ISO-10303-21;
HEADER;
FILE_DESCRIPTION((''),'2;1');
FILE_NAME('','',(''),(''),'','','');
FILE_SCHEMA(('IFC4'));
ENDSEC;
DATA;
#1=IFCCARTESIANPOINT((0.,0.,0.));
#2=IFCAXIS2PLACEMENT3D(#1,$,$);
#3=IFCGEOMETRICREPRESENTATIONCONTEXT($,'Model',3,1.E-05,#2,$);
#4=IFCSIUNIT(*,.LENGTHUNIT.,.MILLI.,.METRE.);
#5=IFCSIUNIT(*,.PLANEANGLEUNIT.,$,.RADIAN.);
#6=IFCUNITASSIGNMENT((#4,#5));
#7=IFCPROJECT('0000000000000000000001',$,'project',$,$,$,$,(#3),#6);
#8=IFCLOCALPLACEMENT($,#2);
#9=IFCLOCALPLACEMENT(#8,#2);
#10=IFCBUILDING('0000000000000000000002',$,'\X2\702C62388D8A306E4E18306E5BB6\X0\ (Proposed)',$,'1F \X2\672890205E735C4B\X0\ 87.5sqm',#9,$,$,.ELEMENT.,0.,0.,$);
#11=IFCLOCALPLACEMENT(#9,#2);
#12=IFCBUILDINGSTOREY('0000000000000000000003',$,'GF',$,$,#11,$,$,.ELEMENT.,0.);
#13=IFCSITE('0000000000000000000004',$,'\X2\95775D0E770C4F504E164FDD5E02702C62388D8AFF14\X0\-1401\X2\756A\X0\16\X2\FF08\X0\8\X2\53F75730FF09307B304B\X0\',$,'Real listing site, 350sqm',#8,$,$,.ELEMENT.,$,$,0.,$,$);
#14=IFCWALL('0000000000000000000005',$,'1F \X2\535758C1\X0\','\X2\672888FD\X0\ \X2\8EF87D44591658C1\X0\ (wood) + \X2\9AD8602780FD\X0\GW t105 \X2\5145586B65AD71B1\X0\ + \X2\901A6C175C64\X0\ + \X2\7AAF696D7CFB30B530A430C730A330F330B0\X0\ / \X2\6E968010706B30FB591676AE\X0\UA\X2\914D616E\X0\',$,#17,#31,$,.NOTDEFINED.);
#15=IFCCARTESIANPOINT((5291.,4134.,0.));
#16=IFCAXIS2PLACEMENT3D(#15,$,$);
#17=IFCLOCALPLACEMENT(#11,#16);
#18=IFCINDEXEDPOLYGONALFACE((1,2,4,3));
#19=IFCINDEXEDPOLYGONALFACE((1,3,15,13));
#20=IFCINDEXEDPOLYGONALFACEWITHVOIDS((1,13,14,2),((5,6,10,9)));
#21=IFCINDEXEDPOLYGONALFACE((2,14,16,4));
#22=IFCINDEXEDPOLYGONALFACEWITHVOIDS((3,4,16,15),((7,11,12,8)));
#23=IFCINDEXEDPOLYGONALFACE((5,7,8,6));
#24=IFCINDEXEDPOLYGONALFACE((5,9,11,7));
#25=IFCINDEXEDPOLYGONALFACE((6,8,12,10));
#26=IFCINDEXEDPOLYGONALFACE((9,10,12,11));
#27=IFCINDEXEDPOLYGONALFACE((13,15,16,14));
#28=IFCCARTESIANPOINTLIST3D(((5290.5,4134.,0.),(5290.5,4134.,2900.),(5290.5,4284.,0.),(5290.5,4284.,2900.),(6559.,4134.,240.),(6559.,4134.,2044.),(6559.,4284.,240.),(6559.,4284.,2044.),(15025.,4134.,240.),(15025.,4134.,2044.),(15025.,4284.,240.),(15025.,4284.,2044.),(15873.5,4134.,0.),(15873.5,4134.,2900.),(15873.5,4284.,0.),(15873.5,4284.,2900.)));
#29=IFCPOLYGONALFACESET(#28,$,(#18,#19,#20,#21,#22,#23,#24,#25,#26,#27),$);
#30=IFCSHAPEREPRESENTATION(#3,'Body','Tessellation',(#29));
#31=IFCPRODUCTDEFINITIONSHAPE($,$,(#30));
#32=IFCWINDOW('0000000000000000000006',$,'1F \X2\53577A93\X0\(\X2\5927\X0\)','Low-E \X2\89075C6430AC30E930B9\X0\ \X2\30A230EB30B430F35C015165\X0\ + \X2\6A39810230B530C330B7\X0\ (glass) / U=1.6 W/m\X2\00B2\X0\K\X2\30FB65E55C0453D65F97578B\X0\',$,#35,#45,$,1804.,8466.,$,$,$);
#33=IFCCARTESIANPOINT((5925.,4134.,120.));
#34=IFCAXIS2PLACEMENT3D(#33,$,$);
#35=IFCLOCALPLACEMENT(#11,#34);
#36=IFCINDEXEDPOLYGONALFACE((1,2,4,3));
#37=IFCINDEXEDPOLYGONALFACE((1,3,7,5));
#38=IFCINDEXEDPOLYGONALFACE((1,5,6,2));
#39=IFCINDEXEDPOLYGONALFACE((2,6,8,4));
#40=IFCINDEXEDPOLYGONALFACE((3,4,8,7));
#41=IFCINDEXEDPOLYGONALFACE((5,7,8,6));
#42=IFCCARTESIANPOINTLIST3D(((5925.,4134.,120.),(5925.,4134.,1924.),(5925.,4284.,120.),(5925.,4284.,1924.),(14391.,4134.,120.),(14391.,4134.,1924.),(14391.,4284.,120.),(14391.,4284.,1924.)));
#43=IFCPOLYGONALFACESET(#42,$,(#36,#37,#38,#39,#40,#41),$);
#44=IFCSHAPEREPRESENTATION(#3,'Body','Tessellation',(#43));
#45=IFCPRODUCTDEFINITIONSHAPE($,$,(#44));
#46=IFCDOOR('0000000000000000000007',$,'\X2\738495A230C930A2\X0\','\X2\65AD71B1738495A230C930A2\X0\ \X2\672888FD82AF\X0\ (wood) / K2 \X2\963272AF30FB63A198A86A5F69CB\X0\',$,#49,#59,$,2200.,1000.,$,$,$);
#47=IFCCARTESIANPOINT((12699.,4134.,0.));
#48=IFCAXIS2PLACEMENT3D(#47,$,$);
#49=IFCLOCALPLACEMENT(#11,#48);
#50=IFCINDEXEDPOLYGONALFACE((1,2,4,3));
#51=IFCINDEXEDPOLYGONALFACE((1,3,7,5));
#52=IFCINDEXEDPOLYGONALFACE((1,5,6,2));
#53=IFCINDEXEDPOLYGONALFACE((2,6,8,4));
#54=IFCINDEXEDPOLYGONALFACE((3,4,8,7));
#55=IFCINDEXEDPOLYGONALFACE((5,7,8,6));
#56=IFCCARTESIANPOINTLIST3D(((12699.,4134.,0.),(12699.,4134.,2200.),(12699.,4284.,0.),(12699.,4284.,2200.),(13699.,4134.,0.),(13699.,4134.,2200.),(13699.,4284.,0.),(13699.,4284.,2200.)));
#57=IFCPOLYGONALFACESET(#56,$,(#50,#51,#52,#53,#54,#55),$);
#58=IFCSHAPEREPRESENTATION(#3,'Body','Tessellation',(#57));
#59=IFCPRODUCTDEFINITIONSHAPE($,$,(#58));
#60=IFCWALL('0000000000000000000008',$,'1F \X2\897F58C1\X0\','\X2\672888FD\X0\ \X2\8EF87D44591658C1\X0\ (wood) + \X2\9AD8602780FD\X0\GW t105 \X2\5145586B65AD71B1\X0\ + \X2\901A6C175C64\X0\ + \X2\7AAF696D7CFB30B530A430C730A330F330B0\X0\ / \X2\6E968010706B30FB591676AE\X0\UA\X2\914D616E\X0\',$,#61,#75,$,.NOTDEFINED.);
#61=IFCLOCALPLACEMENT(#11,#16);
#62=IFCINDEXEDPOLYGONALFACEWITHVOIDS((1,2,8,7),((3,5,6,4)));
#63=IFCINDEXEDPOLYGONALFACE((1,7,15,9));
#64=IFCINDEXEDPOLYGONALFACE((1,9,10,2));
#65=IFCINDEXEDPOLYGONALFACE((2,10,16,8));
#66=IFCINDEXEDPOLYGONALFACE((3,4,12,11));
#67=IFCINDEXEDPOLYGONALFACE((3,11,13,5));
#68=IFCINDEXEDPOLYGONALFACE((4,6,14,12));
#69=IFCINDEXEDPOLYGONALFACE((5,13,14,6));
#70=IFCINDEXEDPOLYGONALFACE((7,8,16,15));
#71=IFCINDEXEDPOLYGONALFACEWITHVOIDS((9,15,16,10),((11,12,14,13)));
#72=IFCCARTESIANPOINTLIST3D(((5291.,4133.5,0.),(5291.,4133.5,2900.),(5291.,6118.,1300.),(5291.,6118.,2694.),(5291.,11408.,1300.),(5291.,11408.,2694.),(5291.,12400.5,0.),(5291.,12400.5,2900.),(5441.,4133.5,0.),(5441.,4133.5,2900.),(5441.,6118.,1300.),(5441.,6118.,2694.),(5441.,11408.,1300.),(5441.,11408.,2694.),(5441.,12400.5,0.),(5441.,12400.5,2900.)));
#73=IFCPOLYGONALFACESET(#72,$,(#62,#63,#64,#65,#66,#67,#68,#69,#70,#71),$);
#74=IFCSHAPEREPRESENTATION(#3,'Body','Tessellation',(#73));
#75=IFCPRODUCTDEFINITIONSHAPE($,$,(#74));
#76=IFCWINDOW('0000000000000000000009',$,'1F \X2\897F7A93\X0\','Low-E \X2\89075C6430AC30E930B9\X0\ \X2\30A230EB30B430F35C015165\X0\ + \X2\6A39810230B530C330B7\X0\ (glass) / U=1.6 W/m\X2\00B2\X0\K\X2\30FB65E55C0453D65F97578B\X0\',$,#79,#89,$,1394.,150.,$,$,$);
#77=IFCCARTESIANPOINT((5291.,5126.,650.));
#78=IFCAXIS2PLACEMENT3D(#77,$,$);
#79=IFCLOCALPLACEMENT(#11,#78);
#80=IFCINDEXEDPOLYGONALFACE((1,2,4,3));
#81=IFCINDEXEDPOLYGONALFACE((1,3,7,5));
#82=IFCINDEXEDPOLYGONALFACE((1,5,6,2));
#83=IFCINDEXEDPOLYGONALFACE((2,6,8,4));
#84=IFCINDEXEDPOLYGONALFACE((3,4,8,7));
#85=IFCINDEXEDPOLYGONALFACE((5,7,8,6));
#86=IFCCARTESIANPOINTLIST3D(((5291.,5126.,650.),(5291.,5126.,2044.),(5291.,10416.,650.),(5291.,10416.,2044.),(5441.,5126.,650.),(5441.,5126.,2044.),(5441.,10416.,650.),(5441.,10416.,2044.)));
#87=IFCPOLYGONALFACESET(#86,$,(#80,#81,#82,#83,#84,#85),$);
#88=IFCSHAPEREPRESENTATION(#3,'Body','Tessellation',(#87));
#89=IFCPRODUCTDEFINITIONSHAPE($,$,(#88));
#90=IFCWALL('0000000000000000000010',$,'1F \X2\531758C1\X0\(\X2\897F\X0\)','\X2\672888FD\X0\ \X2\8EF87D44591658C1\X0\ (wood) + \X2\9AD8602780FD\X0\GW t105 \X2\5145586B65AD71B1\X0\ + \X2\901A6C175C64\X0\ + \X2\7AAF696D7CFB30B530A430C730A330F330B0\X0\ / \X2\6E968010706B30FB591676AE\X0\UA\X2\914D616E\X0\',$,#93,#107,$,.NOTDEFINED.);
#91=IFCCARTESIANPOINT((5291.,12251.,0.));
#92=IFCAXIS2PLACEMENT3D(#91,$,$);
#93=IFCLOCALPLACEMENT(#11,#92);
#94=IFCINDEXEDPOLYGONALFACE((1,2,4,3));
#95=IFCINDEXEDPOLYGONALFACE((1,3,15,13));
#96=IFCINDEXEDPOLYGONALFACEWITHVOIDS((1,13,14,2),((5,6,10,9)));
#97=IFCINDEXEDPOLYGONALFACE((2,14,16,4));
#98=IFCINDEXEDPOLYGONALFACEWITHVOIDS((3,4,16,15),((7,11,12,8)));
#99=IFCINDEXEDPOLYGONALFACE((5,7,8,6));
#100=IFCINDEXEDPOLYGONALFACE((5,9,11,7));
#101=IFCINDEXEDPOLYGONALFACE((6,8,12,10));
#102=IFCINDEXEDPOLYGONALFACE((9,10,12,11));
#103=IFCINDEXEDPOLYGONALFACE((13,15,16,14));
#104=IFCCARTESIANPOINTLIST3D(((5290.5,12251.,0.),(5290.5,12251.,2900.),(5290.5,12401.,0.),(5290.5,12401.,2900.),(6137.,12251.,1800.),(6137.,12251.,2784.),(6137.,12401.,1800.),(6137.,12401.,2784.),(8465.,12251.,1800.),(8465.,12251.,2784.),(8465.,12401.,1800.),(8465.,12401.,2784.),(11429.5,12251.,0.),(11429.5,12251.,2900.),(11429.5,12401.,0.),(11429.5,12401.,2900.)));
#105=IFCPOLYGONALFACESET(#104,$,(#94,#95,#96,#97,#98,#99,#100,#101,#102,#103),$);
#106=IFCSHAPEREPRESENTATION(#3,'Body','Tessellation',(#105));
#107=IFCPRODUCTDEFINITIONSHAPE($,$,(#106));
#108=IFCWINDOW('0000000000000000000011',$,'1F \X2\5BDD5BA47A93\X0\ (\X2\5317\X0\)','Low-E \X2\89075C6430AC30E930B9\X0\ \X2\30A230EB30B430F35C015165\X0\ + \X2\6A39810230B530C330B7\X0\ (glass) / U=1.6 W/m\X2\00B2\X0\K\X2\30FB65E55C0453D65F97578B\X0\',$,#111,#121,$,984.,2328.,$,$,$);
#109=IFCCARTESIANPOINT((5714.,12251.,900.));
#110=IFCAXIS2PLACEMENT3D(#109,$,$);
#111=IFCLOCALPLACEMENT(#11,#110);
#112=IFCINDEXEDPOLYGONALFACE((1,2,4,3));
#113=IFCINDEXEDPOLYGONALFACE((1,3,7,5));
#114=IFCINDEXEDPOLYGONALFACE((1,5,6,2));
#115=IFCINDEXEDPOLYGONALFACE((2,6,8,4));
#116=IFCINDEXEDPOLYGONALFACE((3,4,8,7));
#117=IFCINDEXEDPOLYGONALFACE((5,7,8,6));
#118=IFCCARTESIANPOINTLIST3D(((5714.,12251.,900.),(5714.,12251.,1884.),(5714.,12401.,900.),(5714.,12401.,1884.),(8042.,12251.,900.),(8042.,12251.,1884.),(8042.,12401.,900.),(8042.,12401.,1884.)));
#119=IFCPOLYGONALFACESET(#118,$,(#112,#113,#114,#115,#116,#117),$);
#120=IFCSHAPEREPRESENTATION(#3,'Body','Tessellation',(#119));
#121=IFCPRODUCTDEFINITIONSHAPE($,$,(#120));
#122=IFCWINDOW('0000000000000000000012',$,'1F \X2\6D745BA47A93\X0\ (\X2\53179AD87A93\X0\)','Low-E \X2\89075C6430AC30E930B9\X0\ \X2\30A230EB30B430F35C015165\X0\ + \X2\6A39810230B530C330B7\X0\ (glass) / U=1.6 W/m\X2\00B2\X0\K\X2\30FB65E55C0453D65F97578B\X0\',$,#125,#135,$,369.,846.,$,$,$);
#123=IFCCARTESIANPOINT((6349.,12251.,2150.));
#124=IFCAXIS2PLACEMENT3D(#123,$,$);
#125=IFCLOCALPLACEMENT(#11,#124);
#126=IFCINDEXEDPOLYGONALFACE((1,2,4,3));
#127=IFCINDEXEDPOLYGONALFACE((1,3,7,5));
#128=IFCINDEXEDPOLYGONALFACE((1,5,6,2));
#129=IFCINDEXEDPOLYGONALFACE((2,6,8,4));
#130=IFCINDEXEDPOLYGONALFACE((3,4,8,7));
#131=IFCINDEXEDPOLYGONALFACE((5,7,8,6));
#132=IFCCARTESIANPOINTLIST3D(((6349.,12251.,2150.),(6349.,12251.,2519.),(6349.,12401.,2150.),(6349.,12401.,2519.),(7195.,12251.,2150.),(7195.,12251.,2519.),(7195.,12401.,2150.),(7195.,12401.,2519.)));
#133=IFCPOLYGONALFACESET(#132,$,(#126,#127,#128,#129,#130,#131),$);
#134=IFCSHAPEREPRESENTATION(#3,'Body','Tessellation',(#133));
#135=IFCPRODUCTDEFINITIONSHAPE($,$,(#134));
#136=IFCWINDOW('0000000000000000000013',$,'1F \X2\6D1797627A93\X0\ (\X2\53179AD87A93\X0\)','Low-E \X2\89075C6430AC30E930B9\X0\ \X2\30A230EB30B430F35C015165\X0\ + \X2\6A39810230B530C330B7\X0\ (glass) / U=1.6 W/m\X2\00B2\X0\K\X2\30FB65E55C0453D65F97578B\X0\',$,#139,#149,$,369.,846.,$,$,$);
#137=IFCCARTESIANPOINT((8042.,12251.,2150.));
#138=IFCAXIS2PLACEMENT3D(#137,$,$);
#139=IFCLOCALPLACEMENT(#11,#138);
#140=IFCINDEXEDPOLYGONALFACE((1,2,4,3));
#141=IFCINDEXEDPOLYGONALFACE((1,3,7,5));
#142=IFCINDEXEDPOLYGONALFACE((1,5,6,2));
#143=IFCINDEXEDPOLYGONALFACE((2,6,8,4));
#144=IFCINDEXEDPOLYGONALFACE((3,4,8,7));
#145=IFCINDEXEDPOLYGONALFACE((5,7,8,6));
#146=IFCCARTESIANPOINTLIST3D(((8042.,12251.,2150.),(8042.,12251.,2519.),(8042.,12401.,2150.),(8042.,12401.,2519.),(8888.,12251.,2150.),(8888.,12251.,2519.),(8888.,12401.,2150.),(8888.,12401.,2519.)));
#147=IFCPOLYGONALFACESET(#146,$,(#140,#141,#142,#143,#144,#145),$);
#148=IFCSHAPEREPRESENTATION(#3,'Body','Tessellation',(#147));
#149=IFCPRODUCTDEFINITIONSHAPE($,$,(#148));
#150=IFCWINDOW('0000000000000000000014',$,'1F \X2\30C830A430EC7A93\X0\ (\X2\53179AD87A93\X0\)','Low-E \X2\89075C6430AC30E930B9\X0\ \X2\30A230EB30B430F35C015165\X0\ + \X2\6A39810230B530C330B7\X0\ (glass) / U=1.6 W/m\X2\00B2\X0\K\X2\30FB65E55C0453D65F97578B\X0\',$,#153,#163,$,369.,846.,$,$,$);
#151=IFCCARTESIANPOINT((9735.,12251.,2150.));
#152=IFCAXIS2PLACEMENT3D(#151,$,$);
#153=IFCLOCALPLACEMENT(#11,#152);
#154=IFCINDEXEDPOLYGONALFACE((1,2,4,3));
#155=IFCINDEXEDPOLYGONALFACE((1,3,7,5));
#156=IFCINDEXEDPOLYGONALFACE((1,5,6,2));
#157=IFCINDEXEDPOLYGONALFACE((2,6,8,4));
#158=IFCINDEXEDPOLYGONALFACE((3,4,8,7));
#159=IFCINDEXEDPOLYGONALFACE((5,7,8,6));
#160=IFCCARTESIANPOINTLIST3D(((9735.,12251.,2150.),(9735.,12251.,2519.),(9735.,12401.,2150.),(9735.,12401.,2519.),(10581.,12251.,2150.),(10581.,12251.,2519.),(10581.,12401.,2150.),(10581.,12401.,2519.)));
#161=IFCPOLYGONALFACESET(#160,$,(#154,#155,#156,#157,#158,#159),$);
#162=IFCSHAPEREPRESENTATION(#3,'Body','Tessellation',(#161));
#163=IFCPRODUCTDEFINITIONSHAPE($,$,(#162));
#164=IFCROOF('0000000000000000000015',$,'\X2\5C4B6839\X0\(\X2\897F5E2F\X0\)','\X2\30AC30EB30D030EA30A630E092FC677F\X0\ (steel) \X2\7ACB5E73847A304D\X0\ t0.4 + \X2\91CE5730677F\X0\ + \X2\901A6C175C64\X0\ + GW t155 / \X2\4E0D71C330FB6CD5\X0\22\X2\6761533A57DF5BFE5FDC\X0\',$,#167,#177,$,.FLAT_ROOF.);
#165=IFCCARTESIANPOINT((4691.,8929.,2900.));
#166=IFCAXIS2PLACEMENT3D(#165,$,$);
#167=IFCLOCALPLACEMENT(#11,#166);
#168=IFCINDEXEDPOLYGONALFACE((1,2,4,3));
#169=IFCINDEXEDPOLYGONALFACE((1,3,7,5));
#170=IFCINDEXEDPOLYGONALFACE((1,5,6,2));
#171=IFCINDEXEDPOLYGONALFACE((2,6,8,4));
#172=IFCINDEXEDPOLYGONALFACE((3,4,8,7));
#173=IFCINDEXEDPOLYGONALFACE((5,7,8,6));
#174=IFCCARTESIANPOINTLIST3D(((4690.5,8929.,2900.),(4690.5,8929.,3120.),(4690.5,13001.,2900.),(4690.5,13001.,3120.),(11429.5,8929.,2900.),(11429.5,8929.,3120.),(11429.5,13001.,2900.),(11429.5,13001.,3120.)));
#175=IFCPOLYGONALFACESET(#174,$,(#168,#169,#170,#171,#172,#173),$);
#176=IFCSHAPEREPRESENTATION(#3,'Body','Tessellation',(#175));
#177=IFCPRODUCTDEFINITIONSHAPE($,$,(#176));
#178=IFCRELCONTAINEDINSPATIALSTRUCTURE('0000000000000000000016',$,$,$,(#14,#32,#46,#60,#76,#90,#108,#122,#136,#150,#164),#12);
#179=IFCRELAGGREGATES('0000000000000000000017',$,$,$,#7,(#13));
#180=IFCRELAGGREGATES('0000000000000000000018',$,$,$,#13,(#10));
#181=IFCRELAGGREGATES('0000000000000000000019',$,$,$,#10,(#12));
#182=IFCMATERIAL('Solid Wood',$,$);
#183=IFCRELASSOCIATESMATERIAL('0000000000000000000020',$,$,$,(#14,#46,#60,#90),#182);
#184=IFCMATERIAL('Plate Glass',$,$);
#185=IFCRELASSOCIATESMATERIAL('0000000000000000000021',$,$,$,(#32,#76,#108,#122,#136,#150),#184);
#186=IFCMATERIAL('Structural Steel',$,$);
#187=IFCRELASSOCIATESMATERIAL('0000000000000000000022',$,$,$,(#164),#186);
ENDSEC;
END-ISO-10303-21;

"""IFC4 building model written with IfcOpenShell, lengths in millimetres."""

from ifc_helpers import new_model, si_unit, frame, frame_2d, origin, place, context, project, spatial, rectangle, extrude, material, element, fill, save


model = new_model("IFC4")

# Units and contexts
model_context = context("Model", 3, precision=1e-05, world=origin())
ifc_project = project(units=[si_unit("LENGTHUNIT", "METRE", prefix="MILLI"), si_unit("PLANEANGLEUNIT", "RADIAN")], contexts=[model_context])

# Site, building, storey
site_placement = place(None, origin())
site = spatial("IfcSite", under=ifc_project, at=site_placement, Name="長崎県佐世保市瀬戸越４-1401番16（8号地）ほか", ObjectType="Real listing site, 350sqm", CompositionType="ELEMENT", RefElevation=0.0)
building_placement = place(site_placement, origin())
building = spatial("IfcBuilding", under=site, at=building_placement, Name="瀬戸越の丘の家 (Proposed)", ObjectType="1F 木造平屋 87.5sqm", CompositionType="ELEMENT", ElevationOfRefHeight=0.0, ElevationOfTerrain=0.0)
storey_placement = place(building_placement, origin())
storey = spatial("IfcBuildingStorey", under=building, at=storey_placement, Name="GF", CompositionType="ELEMENT", Elevation=0.0)

# Shared definitions
ifc_material_1 = material(Name="Solid Wood")

# Wall, openings, window, door
wall_1_placement = place(storey_placement, frame((5291.0, 4134.0, 0.0)))
wall_1 = element("IfcWall", 1, at=wall_1_placement, inside=storey, material=ifc_material_1, Name="1F 南壁", Description="木製 軸組外壁 (wood) + 高性能GW t105 充填断熱 + 通気層 + 窯業系サイディング / 準耐火・外皮UA配慮", PredefinedType="NOTDEFINED", context=model_context, shape_type="SweptSolid", body=[
    extrude(rectangle(XDim=10583.0, YDim=150.0, at=frame_2d((5291.0, 75.0))), frame((5291.0, 4134.0, 0.0)), (0.0, 0.0, 1.0), 2900.0),
])
opening_1_placement = place(storey_placement, frame((5925.0, 4134.0, 120.0)))
opening_1 = element("IfcOpeningElement", 2, at=opening_1_placement, cuts=wall_1, PredefinedType="NOTDEFINED", context=model_context, shape_type="SweptSolid", body=[
    extrude(rectangle(XDim=8466.0, YDim=150.0, at=frame_2d((4233.0, 75.0))), frame((5925.0, 4134.0, 120.0)), (0.0, 0.0, 1.0), 1804.0),
])
opening_2_placement = place(storey_placement, frame((12699.0, 4134.0, 0.0)))
opening_2 = element("IfcOpeningElement", 3, at=opening_2_placement, cuts=wall_1, PredefinedType="NOTDEFINED", context=model_context, shape_type="SweptSolid", body=[
    extrude(rectangle(XDim=1000.0, YDim=150.0, at=frame_2d((500.0, 75.0))), frame((12699.0, 4134.0, 0.0)), (0.0, 0.0, 1.0), 2200.0),
])
ifc_material_2 = material(Name="Plate Glass")
window_1_placement = place(storey_placement, frame((5925.0, 4134.0, 120.0)))
window_1 = element("IfcWindow", 4, at=window_1_placement, inside=storey, material=ifc_material_2, Name="1F 南窓(大)", Description="Low-E 複層ガラス アルゴン封入 + 樹脂サッシ (glass) / U=1.6 W/m²K・日射取得型", OverallHeight=1804.0, OverallWidth=8466.0, context=model_context, shape_type="SweptSolid", body=[
    extrude(rectangle(XDim=8466.0, YDim=150.0, at=frame_2d((4233.0, 75.0))), frame((5925.0, 4134.0, 120.0)), (0.0, 0.0, 1.0), 1804.0),
])
fill(opening_1, window_1)
door_1_placement = place(storey_placement, frame((12699.0, 4134.0, 0.0)))
door_1 = element("IfcDoor", 5, at=door_1_placement, inside=storey, material=ifc_material_1, Name="玄関ドア", Description="断熱玄関ドア 木製芯 (wood) / K2 防犯・採風機構", OverallHeight=2200.0, OverallWidth=1000.0, context=model_context, shape_type="SweptSolid", body=[
    extrude(rectangle(XDim=1000.0, YDim=150.0, at=frame_2d((500.0, 75.0))), frame((12699.0, 4134.0, 0.0)), (0.0, 0.0, 1.0), 2200.0),
])
fill(opening_2, door_1)

# Wall, opening, window
wall_2_placement = place(storey_placement, frame((5291.0, 4134.0, 0.0)))
wall_2 = element("IfcWall", 6, at=wall_2_placement, inside=storey, material=ifc_material_1, Name="1F 西壁", Description="木製 軸組外壁 (wood) + 高性能GW t105 充填断熱 + 通気層 + 窯業系サイディング / 準耐火・外皮UA配慮", PredefinedType="NOTDEFINED", context=model_context, shape_type="SweptSolid", body=[
    extrude(rectangle(XDim=150.0, YDim=8267.0, at=frame_2d((75.0, 4133.0))), frame((5291.0, 4134.0, 0.0)), (0.0, 0.0, 1.0), 2900.0),
])
opening_3_placement = place(storey_placement, frame((5291.0, 5126.0, 650.0)))
opening_3 = element("IfcOpeningElement", 7, at=opening_3_placement, cuts=wall_2, PredefinedType="NOTDEFINED", context=model_context, shape_type="SweptSolid", body=[
    extrude(rectangle(XDim=150.0, YDim=5290.0, at=frame_2d((75.0, 2645.0))), frame((5291.0, 5126.0, 650.0)), (0.0, 0.0, 1.0), 1394.0),
])
window_2_placement = place(storey_placement, frame((5291.0, 5126.0, 650.0)))
window_2 = element("IfcWindow", 8, at=window_2_placement, inside=storey, material=ifc_material_2, Name="1F 西窓", Description="Low-E 複層ガラス アルゴン封入 + 樹脂サッシ (glass) / U=1.6 W/m²K・日射取得型", OverallHeight=1394.0, OverallWidth=150.0, context=model_context, shape_type="SweptSolid", body=[
    extrude(rectangle(XDim=150.0, YDim=5290.0, at=frame_2d((75.0, 2645.0))), frame((5291.0, 5126.0, 650.0)), (0.0, 0.0, 1.0), 1394.0),
])
fill(opening_3, window_2)

# Wall, openings, windows
wall_3_placement = place(storey_placement, frame((5291.0, 12251.0, 0.0)))
wall_3 = element("IfcWall", 9, at=wall_3_placement, inside=storey, material=ifc_material_1, Name="1F 北壁(西)", Description="木製 軸組外壁 (wood) + 高性能GW t105 充填断熱 + 通気層 + 窯業系サイディング / 準耐火・外皮UA配慮", PredefinedType="NOTDEFINED", context=model_context, shape_type="SweptSolid", body=[
    extrude(rectangle(XDim=6139.0, YDim=150.0, at=frame_2d((3069.0, 75.0))), frame((5291.0, 12251.0, 0.0)), (0.0, 0.0, 1.0), 2900.0),
])
opening_4_placement = place(storey_placement, frame((5714.0, 12251.0, 900.0)))
opening_4 = element("IfcOpeningElement", 10, at=opening_4_placement, cuts=wall_3, PredefinedType="NOTDEFINED", context=model_context, shape_type="SweptSolid", body=[
    extrude(rectangle(XDim=2328.0, YDim=150.0, at=frame_2d((1164.0, 75.0))), frame((5714.0, 12251.0, 900.0)), (0.0, 0.0, 1.0), 984.0),
])
opening_5_placement = place(storey_placement, frame((6349.0, 12251.0, 2150.0)))
opening_5 = element("IfcOpeningElement", 11, at=opening_5_placement, cuts=wall_3, PredefinedType="NOTDEFINED", context=model_context, shape_type="SweptSolid", body=[
    extrude(rectangle(XDim=846.0, YDim=150.0, at=frame_2d((423.0, 75.0))), frame((6349.0, 12251.0, 2150.0)), (0.0, 0.0, 1.0), 369.0),
])
opening_6_placement = place(storey_placement, frame((8042.0, 12251.0, 2150.0)))
opening_6 = element("IfcOpeningElement", 12, at=opening_6_placement, cuts=wall_3, PredefinedType="NOTDEFINED", context=model_context, shape_type="SweptSolid", body=[
    extrude(rectangle(XDim=846.0, YDim=150.0, at=frame_2d((423.0, 75.0))), frame((8042.0, 12251.0, 2150.0)), (0.0, 0.0, 1.0), 369.0),
])
opening_7_placement = place(storey_placement, frame((9735.0, 12251.0, 2150.0)))
opening_7 = element("IfcOpeningElement", 13, at=opening_7_placement, cuts=wall_3, PredefinedType="NOTDEFINED", context=model_context, shape_type="SweptSolid", body=[
    extrude(rectangle(XDim=846.0, YDim=150.0, at=frame_2d((423.0, 75.0))), frame((9735.0, 12251.0, 2150.0)), (0.0, 0.0, 1.0), 369.0),
])
window_3_placement = place(storey_placement, frame((5714.0, 12251.0, 900.0)))
window_3 = element("IfcWindow", 14, at=window_3_placement, inside=storey, material=ifc_material_2, Name="1F 寝室窓 (北)", Description="Low-E 複層ガラス アルゴン封入 + 樹脂サッシ (glass) / U=1.6 W/m²K・日射取得型", OverallHeight=984.0, OverallWidth=2328.0, context=model_context, shape_type="SweptSolid", body=[
    extrude(rectangle(XDim=2328.0, YDim=150.0, at=frame_2d((1164.0, 75.0))), frame((5714.0, 12251.0, 900.0)), (0.0, 0.0, 1.0), 984.0),
])
fill(opening_4, window_3)
window_4_placement = place(storey_placement, frame((6349.0, 12251.0, 2150.0)))
window_4 = element("IfcWindow", 15, at=window_4_placement, inside=storey, material=ifc_material_2, Name="1F 浴室窓 (北高窓)", Description="Low-E 複層ガラス アルゴン封入 + 樹脂サッシ (glass) / U=1.6 W/m²K・日射取得型", OverallHeight=369.0, OverallWidth=846.0, context=model_context, shape_type="SweptSolid", body=[
    extrude(rectangle(XDim=846.0, YDim=150.0, at=frame_2d((423.0, 75.0))), frame((6349.0, 12251.0, 2150.0)), (0.0, 0.0, 1.0), 369.0),
])
fill(opening_5, window_4)
window_5_placement = place(storey_placement, frame((8042.0, 12251.0, 2150.0)))
window_5 = element("IfcWindow", 16, at=window_5_placement, inside=storey, material=ifc_material_2, Name="1F 洗面窓 (北高窓)", Description="Low-E 複層ガラス アルゴン封入 + 樹脂サッシ (glass) / U=1.6 W/m²K・日射取得型", OverallHeight=369.0, OverallWidth=846.0, context=model_context, shape_type="SweptSolid", body=[
    extrude(rectangle(XDim=846.0, YDim=150.0, at=frame_2d((423.0, 75.0))), frame((8042.0, 12251.0, 2150.0)), (0.0, 0.0, 1.0), 369.0),
])
fill(opening_6, window_5)
window_6_placement = place(storey_placement, frame((9735.0, 12251.0, 2150.0)))
window_6 = element("IfcWindow", 17, at=window_6_placement, inside=storey, material=ifc_material_2, Name="1F トイレ窓 (北高窓)", Description="Low-E 複層ガラス アルゴン封入 + 樹脂サッシ (glass) / U=1.6 W/m²K・日射取得型", OverallHeight=369.0, OverallWidth=846.0, context=model_context, shape_type="SweptSolid", body=[
    extrude(rectangle(XDim=846.0, YDim=150.0, at=frame_2d((423.0, 75.0))), frame((9735.0, 12251.0, 2150.0)), (0.0, 0.0, 1.0), 369.0),
])
fill(opening_7, window_6)

# Roof
ifc_material_3 = material(Name="Structural Steel")
roof_1_placement = place(storey_placement, frame((4691.0, 8929.0, 2900.0)))
element("IfcRoof", 18, at=roof_1_placement, inside=storey, material=ifc_material_3, Name="屋根(西帯)", Description="ガルバリウム鋼板 (steel) 立平葺き t0.4 + 野地板 + 通気層 + GW t155 / 不燃・法22条区域対応", PredefinedType="FLAT_ROOF", context=model_context, shape_type="SweptSolid", body=[
    extrude(rectangle(XDim=6739.0, YDim=4072.0, at=frame_2d((3369.0, 2036.0))), frame((4691.0, 8929.0, 2900.0)), (0.0, 0.0, 1.0), 220.0),
])

save(model, "model.ifc")
